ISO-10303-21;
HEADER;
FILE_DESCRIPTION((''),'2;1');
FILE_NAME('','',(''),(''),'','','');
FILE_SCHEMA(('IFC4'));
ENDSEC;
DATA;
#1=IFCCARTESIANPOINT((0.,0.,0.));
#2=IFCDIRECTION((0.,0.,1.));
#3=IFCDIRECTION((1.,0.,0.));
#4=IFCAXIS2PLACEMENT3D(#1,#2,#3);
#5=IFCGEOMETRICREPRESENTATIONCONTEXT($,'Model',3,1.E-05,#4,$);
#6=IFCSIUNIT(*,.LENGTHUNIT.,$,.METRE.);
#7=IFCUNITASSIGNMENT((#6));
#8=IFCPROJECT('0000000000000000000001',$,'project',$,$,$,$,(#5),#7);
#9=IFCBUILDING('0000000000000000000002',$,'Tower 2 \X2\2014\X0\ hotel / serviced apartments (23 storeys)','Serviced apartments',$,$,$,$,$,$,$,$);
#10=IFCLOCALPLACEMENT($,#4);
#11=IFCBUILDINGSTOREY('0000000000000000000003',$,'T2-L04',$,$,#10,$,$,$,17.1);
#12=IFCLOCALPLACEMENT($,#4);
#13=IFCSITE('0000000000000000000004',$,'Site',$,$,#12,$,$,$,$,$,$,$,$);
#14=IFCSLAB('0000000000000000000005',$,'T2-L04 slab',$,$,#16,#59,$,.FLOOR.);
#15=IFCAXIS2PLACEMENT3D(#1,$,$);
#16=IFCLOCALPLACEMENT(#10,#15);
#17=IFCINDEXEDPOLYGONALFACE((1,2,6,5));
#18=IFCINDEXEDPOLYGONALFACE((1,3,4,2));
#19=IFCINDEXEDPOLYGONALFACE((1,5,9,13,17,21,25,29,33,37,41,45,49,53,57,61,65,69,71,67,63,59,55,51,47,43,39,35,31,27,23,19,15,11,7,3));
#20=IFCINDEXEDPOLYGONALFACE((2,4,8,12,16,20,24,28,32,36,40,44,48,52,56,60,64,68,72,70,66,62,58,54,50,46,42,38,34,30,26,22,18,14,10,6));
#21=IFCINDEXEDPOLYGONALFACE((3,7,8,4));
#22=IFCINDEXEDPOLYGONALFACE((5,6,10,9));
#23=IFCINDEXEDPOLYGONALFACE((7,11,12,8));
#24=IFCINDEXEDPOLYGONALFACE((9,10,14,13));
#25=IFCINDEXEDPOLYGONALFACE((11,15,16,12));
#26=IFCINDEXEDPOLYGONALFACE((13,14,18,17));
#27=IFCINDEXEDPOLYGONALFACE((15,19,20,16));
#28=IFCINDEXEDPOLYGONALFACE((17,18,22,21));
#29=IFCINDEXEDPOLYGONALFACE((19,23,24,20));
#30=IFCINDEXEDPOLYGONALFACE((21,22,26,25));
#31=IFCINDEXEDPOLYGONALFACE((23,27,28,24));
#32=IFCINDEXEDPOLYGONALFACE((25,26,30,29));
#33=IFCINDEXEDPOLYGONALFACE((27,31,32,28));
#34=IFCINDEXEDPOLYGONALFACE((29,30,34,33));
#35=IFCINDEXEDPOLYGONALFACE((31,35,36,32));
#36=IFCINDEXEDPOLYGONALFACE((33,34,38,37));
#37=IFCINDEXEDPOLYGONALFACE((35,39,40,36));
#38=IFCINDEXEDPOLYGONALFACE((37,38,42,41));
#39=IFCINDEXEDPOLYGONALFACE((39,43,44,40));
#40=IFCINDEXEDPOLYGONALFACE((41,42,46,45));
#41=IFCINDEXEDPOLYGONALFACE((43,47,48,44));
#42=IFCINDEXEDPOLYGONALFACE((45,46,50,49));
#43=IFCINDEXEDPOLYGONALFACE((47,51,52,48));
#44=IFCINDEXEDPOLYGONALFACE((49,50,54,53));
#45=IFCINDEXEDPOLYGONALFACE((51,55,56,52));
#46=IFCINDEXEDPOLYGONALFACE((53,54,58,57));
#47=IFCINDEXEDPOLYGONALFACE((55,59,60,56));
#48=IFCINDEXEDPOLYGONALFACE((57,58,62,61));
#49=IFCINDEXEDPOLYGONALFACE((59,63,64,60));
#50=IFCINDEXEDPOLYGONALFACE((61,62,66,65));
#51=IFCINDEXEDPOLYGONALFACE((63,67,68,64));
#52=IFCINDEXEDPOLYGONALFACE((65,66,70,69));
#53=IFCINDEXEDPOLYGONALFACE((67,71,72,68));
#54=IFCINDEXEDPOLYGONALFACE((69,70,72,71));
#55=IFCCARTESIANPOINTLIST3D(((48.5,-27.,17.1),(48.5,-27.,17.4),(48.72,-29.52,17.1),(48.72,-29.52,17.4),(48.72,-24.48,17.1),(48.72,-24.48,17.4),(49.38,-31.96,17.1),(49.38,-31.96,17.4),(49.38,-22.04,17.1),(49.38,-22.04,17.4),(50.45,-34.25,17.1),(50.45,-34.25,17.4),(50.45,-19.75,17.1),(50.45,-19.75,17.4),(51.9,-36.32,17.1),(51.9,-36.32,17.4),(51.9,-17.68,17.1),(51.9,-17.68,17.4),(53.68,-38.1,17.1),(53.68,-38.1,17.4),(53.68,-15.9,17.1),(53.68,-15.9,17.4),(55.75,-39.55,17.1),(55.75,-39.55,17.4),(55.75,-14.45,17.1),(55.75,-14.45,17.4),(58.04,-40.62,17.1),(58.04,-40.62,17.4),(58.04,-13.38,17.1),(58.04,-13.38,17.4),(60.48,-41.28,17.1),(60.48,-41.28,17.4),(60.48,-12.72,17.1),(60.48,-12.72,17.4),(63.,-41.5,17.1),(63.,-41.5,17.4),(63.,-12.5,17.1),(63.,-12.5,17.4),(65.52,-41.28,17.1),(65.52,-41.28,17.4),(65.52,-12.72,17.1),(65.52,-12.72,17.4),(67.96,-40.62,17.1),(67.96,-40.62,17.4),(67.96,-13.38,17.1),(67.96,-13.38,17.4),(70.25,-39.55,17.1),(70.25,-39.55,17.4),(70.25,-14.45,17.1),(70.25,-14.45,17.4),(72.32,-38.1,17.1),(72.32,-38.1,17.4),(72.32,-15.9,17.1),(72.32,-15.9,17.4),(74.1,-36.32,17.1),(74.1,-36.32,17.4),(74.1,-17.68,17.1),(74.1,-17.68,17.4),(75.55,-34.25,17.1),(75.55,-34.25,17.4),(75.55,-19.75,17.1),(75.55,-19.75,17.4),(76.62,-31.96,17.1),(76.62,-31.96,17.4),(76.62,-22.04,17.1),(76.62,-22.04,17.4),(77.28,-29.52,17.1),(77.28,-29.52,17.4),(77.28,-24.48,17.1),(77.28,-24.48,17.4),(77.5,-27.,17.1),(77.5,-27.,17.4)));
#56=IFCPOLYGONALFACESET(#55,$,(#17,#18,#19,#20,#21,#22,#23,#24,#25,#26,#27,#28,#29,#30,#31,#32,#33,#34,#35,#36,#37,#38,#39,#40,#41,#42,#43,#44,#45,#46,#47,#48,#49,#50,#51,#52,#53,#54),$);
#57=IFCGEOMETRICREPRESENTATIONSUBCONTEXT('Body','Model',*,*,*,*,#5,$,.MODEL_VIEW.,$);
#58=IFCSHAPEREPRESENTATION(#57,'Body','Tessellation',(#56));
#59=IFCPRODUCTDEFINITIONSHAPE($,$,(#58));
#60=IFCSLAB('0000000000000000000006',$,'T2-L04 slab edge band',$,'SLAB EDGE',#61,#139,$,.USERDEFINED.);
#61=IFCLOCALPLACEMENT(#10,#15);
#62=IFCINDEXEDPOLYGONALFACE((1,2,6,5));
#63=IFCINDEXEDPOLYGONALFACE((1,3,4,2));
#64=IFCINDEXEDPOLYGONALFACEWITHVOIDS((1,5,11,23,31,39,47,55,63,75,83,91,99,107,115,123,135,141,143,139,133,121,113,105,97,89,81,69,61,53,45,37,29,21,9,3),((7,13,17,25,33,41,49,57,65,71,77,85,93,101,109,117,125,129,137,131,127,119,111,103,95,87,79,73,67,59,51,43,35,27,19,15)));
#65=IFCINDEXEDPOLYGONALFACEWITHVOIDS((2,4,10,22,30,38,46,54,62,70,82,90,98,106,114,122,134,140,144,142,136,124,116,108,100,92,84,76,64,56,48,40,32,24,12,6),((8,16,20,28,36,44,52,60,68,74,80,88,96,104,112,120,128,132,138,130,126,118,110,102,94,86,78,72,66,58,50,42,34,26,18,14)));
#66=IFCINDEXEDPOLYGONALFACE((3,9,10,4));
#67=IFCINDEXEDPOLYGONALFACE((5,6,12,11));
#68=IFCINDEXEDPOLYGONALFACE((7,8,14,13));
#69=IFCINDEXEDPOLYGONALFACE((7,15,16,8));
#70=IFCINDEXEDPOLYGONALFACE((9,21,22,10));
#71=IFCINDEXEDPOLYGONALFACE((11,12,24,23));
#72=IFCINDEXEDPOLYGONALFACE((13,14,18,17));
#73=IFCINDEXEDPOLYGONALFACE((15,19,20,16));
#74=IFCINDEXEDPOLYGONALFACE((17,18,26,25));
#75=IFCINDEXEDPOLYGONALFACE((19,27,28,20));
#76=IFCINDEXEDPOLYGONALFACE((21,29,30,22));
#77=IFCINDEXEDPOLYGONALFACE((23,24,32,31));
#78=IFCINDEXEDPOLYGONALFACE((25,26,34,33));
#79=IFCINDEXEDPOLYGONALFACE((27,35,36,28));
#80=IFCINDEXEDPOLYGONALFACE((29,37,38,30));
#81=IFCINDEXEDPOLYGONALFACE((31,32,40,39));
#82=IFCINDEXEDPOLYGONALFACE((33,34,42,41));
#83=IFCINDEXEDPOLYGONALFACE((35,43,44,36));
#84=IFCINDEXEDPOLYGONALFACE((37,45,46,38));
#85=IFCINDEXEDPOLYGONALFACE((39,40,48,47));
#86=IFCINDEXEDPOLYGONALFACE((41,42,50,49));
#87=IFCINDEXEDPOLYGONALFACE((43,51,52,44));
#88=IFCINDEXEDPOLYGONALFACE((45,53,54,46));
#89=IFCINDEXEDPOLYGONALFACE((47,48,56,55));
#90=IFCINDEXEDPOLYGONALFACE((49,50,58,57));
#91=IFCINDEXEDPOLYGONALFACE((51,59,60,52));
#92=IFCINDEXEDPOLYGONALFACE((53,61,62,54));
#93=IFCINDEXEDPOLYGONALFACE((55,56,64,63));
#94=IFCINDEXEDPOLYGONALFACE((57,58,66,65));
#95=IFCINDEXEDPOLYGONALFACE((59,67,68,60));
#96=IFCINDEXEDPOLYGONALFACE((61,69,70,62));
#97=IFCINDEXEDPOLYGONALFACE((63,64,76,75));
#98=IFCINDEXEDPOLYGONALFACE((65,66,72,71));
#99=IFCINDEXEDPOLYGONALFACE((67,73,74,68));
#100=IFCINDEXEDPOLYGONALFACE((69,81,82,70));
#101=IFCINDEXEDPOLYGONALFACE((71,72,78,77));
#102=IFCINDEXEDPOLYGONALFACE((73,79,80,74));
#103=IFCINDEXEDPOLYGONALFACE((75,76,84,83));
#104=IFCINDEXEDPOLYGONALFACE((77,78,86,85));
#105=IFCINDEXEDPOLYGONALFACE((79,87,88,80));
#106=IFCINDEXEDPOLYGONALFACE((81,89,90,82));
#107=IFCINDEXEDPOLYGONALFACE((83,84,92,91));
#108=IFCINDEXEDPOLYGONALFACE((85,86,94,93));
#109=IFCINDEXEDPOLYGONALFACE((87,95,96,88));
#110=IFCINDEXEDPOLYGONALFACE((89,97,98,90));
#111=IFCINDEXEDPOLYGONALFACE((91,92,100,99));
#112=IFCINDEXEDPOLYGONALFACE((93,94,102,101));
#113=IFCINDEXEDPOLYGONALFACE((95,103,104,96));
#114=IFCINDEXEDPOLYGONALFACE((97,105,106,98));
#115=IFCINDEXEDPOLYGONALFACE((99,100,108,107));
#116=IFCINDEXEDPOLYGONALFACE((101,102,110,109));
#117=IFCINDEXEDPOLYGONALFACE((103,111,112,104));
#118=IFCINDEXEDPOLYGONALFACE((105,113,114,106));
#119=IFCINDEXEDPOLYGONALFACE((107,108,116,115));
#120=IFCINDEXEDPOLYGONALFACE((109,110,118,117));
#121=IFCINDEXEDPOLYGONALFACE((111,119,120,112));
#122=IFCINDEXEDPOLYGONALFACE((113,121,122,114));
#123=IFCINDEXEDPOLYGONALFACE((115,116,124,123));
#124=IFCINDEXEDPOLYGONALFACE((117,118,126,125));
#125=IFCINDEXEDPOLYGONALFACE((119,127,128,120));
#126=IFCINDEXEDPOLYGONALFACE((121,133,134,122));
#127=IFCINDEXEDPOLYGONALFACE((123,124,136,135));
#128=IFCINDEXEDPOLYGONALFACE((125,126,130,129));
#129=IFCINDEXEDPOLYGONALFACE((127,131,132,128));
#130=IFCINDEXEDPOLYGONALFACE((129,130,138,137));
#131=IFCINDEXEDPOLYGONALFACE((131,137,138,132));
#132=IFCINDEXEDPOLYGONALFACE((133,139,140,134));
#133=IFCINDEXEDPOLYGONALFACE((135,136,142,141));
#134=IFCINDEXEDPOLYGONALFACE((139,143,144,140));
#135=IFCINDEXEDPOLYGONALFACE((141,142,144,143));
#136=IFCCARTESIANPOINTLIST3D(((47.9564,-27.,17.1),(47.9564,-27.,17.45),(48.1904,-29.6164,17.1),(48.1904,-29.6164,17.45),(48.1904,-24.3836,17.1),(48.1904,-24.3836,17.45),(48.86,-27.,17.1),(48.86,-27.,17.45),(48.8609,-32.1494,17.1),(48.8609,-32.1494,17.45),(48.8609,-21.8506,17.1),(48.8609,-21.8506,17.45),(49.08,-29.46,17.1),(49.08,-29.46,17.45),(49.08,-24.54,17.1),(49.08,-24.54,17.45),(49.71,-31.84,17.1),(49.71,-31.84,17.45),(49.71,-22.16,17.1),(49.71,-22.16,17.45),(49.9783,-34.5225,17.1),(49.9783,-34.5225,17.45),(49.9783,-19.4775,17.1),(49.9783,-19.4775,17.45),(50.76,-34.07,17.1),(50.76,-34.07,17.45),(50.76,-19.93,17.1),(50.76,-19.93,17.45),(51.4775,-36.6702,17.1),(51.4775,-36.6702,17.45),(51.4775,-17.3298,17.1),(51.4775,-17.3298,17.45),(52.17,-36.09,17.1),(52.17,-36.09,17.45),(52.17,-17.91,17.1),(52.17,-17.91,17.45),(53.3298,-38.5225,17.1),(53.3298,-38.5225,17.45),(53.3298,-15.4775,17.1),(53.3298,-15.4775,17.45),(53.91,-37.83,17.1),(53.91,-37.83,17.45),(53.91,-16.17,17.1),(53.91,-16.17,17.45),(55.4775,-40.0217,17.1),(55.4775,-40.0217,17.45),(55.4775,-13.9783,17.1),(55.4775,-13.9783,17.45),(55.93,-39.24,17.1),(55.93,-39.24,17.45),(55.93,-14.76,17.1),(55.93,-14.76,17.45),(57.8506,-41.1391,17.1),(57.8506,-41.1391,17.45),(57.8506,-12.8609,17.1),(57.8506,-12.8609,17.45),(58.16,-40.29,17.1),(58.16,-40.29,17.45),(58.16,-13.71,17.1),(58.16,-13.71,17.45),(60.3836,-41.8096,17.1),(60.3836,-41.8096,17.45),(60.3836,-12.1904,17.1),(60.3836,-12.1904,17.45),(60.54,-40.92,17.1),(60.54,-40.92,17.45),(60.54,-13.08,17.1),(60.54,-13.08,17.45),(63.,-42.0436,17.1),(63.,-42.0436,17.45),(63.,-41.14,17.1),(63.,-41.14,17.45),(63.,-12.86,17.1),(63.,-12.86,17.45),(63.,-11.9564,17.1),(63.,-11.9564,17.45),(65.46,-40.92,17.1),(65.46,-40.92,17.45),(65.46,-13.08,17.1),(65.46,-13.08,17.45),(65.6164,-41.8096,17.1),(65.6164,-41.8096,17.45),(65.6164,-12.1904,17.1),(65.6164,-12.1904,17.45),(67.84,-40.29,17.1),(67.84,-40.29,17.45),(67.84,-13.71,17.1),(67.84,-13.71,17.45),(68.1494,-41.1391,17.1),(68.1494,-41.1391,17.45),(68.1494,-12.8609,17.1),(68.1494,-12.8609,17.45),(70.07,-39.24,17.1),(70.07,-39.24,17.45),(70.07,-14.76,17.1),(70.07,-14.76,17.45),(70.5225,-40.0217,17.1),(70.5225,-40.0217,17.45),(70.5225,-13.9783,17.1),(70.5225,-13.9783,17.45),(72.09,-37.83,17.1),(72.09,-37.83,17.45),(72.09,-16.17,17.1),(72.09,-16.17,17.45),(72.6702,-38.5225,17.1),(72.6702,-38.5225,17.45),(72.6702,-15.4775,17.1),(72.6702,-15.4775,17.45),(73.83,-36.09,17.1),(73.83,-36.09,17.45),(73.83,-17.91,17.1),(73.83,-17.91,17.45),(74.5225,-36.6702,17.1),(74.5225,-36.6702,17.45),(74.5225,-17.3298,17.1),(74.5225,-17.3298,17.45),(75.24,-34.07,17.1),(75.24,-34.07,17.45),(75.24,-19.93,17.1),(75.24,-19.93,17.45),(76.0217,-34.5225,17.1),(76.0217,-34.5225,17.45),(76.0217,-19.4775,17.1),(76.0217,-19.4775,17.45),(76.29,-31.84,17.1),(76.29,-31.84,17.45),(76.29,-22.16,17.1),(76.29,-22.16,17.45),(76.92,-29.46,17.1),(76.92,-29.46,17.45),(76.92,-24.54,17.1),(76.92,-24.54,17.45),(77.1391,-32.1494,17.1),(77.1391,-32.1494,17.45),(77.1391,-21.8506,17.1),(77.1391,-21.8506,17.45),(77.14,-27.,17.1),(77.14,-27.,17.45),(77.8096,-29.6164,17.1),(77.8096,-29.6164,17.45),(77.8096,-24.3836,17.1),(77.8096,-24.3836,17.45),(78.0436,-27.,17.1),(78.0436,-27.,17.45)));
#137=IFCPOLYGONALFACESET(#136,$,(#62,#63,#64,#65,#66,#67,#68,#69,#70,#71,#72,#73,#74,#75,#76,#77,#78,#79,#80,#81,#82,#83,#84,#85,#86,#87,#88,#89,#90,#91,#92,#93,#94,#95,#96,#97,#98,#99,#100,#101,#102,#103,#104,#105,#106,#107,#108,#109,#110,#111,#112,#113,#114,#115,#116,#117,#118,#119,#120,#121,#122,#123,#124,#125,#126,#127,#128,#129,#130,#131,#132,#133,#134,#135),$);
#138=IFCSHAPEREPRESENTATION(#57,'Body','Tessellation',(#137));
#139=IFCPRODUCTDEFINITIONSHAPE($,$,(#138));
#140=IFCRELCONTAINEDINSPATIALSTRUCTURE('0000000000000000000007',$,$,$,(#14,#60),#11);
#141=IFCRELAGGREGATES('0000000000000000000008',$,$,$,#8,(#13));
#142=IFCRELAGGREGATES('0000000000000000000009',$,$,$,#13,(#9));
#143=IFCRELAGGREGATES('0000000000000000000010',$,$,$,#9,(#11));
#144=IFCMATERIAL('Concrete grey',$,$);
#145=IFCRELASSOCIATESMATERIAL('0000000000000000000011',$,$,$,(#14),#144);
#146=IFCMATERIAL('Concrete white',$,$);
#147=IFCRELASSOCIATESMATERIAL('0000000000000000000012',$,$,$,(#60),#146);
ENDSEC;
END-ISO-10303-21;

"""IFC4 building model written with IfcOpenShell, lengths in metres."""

from ifc_helpers import new_model, si_unit, frame, origin_with_axes, place, context, subcontext, project, spatial, polyline, outline, extrude, material, element, save


model = new_model("IFC4")

# Units and contexts
model_context = context("Model", 3, precision=1e-05, world=origin_with_axes())
body_context = subcontext(model_context, "Body", "Model", "MODEL_VIEW")
ifc_project = project(units=[si_unit("LENGTHUNIT", "METRE")], contexts=[model_context])

# Site, building, storey
site_placement = place(None, origin_with_axes())
site = spatial("IfcSite", under=ifc_project, at=site_placement, Name="Site")
building = spatial("IfcBuilding", under=site, Name="Tower 2 — hotel / serviced apartments (23 storeys)", Description="Serviced apartments")
storey_placement = place(None, origin_with_axes())
storey = spatial("IfcBuildingStorey", under=building, at=storey_placement, Name="T2-L04", Elevation=17.1)

# Slab
ifc_material_1 = material(Name="Concrete grey")
slab_1_placement = place(storey_placement, origin_with_axes())
element("IfcSlab", 1, at=slab_1_placement, inside=storey, material=ifc_material_1, Name="T2-L04 slab", PredefinedType="FLOOR", context=body_context, shape_type="SweptSolid", body=[
    extrude(outline(polyline([(77.28, -29.52), (77.5, -27.0), (77.28, -24.48), (76.62, -22.04), (75.55, -19.75), (74.1, -17.68), (72.32, -15.9), (70.25, -14.45), (67.96, -13.38), (65.52, -12.72), (63.0, -12.5), (60.48, -12.72), (58.04, -13.38), (55.75, -14.45), (53.68, -15.9), (51.9, -17.68), (50.45, -19.75), (49.38, -22.04), (48.72, -24.48), (48.5, -27.0), (48.72, -29.52), (49.38, -31.96), (50.45, -34.25), (51.9, -36.32), (53.68, -38.1), (55.75, -39.55), (58.04, -40.62), (60.48, -41.28), (63.0, -41.5), (65.52, -41.28), (67.96, -40.62), (70.25, -39.55), (72.32, -38.1), (74.1, -36.32), (75.55, -34.25), (76.62, -31.96), (77.28, -29.52)])), frame((0.0, 0.0, 17.1), z_axis=(0.0, 0.0, 1.0), x_axis=(1.0, 0.0, 0.0)), (0.0, 0.0, 1.0), 0.3),
])

# Slab
ifc_material_2 = material(Name="Concrete white")
slab_2_placement = place(storey_placement, origin_with_axes())
element("IfcSlab", 2, at=slab_2_placement, inside=storey, material=ifc_material_2, Name="T2-L04 slab edge band", ObjectType="SLAB EDGE", PredefinedType="USERDEFINED", context=body_context, shape_type="SweptSolid", body=[
    extrude(outline(polyline([(78.0436, -27.0), (77.8096, -24.3836), (77.1391, -21.8506), (76.0217, -19.4775), (74.5225, -17.3298), (72.6702, -15.4775), (70.5225, -13.9783), (68.1494, -12.8609), (65.6164, -12.1904), (63.0, -11.9564), (60.3836, -12.1904), (57.8506, -12.8609), (55.4775, -13.9783), (53.3298, -15.4775), (51.4775, -17.3298), (49.9783, -19.4775), (48.8609, -21.8506), (48.1904, -24.3836), (47.9564, -27.0), (48.1904, -29.6164), (48.8609, -32.1494), (49.9783, -34.5225), (51.4775, -36.6702), (53.3298, -38.5225), (55.4775, -40.0217), (57.8506, -41.1391), (60.3836, -41.8096), (63.0, -42.0436), (65.6164, -41.8096), (68.1494, -41.1391), (70.5225, -40.0217), (72.6702, -38.5225), (74.5225, -36.6702), (76.0217, -34.5225), (77.1391, -32.1494), (77.8096, -29.6164), (78.0436, -27.0)]), holes=[polyline([(77.14, -27.0), (76.92, -24.54), (76.29, -22.16), (75.24, -19.93), (73.83, -17.91), (72.09, -16.17), (70.07, -14.76), (67.84, -13.71), (65.46, -13.08), (63.0, -12.86), (60.54, -13.08), (58.16, -13.71), (55.93, -14.76), (53.91, -16.17), (52.17, -17.91), (50.76, -19.93), (49.71, -22.16), (49.08, -24.54), (48.86, -27.0), (49.08, -29.46), (49.71, -31.84), (50.76, -34.07), (52.17, -36.09), (53.91, -37.83), (55.93, -39.24), (58.16, -40.29), (60.54, -40.92), (63.0, -41.14), (65.46, -40.92), (67.84, -40.29), (70.07, -39.24), (72.09, -37.83), (73.83, -36.09), (75.24, -34.07), (76.29, -31.84), (76.92, -29.46), (77.14, -27.0)])]), frame((0.0, 0.0, 17.1), z_axis=(0.0, 0.0, 1.0), x_axis=(1.0, 0.0, 0.0)), (0.0, 0.0, 1.0), 0.35),
])

save(model, "model.ifc")
